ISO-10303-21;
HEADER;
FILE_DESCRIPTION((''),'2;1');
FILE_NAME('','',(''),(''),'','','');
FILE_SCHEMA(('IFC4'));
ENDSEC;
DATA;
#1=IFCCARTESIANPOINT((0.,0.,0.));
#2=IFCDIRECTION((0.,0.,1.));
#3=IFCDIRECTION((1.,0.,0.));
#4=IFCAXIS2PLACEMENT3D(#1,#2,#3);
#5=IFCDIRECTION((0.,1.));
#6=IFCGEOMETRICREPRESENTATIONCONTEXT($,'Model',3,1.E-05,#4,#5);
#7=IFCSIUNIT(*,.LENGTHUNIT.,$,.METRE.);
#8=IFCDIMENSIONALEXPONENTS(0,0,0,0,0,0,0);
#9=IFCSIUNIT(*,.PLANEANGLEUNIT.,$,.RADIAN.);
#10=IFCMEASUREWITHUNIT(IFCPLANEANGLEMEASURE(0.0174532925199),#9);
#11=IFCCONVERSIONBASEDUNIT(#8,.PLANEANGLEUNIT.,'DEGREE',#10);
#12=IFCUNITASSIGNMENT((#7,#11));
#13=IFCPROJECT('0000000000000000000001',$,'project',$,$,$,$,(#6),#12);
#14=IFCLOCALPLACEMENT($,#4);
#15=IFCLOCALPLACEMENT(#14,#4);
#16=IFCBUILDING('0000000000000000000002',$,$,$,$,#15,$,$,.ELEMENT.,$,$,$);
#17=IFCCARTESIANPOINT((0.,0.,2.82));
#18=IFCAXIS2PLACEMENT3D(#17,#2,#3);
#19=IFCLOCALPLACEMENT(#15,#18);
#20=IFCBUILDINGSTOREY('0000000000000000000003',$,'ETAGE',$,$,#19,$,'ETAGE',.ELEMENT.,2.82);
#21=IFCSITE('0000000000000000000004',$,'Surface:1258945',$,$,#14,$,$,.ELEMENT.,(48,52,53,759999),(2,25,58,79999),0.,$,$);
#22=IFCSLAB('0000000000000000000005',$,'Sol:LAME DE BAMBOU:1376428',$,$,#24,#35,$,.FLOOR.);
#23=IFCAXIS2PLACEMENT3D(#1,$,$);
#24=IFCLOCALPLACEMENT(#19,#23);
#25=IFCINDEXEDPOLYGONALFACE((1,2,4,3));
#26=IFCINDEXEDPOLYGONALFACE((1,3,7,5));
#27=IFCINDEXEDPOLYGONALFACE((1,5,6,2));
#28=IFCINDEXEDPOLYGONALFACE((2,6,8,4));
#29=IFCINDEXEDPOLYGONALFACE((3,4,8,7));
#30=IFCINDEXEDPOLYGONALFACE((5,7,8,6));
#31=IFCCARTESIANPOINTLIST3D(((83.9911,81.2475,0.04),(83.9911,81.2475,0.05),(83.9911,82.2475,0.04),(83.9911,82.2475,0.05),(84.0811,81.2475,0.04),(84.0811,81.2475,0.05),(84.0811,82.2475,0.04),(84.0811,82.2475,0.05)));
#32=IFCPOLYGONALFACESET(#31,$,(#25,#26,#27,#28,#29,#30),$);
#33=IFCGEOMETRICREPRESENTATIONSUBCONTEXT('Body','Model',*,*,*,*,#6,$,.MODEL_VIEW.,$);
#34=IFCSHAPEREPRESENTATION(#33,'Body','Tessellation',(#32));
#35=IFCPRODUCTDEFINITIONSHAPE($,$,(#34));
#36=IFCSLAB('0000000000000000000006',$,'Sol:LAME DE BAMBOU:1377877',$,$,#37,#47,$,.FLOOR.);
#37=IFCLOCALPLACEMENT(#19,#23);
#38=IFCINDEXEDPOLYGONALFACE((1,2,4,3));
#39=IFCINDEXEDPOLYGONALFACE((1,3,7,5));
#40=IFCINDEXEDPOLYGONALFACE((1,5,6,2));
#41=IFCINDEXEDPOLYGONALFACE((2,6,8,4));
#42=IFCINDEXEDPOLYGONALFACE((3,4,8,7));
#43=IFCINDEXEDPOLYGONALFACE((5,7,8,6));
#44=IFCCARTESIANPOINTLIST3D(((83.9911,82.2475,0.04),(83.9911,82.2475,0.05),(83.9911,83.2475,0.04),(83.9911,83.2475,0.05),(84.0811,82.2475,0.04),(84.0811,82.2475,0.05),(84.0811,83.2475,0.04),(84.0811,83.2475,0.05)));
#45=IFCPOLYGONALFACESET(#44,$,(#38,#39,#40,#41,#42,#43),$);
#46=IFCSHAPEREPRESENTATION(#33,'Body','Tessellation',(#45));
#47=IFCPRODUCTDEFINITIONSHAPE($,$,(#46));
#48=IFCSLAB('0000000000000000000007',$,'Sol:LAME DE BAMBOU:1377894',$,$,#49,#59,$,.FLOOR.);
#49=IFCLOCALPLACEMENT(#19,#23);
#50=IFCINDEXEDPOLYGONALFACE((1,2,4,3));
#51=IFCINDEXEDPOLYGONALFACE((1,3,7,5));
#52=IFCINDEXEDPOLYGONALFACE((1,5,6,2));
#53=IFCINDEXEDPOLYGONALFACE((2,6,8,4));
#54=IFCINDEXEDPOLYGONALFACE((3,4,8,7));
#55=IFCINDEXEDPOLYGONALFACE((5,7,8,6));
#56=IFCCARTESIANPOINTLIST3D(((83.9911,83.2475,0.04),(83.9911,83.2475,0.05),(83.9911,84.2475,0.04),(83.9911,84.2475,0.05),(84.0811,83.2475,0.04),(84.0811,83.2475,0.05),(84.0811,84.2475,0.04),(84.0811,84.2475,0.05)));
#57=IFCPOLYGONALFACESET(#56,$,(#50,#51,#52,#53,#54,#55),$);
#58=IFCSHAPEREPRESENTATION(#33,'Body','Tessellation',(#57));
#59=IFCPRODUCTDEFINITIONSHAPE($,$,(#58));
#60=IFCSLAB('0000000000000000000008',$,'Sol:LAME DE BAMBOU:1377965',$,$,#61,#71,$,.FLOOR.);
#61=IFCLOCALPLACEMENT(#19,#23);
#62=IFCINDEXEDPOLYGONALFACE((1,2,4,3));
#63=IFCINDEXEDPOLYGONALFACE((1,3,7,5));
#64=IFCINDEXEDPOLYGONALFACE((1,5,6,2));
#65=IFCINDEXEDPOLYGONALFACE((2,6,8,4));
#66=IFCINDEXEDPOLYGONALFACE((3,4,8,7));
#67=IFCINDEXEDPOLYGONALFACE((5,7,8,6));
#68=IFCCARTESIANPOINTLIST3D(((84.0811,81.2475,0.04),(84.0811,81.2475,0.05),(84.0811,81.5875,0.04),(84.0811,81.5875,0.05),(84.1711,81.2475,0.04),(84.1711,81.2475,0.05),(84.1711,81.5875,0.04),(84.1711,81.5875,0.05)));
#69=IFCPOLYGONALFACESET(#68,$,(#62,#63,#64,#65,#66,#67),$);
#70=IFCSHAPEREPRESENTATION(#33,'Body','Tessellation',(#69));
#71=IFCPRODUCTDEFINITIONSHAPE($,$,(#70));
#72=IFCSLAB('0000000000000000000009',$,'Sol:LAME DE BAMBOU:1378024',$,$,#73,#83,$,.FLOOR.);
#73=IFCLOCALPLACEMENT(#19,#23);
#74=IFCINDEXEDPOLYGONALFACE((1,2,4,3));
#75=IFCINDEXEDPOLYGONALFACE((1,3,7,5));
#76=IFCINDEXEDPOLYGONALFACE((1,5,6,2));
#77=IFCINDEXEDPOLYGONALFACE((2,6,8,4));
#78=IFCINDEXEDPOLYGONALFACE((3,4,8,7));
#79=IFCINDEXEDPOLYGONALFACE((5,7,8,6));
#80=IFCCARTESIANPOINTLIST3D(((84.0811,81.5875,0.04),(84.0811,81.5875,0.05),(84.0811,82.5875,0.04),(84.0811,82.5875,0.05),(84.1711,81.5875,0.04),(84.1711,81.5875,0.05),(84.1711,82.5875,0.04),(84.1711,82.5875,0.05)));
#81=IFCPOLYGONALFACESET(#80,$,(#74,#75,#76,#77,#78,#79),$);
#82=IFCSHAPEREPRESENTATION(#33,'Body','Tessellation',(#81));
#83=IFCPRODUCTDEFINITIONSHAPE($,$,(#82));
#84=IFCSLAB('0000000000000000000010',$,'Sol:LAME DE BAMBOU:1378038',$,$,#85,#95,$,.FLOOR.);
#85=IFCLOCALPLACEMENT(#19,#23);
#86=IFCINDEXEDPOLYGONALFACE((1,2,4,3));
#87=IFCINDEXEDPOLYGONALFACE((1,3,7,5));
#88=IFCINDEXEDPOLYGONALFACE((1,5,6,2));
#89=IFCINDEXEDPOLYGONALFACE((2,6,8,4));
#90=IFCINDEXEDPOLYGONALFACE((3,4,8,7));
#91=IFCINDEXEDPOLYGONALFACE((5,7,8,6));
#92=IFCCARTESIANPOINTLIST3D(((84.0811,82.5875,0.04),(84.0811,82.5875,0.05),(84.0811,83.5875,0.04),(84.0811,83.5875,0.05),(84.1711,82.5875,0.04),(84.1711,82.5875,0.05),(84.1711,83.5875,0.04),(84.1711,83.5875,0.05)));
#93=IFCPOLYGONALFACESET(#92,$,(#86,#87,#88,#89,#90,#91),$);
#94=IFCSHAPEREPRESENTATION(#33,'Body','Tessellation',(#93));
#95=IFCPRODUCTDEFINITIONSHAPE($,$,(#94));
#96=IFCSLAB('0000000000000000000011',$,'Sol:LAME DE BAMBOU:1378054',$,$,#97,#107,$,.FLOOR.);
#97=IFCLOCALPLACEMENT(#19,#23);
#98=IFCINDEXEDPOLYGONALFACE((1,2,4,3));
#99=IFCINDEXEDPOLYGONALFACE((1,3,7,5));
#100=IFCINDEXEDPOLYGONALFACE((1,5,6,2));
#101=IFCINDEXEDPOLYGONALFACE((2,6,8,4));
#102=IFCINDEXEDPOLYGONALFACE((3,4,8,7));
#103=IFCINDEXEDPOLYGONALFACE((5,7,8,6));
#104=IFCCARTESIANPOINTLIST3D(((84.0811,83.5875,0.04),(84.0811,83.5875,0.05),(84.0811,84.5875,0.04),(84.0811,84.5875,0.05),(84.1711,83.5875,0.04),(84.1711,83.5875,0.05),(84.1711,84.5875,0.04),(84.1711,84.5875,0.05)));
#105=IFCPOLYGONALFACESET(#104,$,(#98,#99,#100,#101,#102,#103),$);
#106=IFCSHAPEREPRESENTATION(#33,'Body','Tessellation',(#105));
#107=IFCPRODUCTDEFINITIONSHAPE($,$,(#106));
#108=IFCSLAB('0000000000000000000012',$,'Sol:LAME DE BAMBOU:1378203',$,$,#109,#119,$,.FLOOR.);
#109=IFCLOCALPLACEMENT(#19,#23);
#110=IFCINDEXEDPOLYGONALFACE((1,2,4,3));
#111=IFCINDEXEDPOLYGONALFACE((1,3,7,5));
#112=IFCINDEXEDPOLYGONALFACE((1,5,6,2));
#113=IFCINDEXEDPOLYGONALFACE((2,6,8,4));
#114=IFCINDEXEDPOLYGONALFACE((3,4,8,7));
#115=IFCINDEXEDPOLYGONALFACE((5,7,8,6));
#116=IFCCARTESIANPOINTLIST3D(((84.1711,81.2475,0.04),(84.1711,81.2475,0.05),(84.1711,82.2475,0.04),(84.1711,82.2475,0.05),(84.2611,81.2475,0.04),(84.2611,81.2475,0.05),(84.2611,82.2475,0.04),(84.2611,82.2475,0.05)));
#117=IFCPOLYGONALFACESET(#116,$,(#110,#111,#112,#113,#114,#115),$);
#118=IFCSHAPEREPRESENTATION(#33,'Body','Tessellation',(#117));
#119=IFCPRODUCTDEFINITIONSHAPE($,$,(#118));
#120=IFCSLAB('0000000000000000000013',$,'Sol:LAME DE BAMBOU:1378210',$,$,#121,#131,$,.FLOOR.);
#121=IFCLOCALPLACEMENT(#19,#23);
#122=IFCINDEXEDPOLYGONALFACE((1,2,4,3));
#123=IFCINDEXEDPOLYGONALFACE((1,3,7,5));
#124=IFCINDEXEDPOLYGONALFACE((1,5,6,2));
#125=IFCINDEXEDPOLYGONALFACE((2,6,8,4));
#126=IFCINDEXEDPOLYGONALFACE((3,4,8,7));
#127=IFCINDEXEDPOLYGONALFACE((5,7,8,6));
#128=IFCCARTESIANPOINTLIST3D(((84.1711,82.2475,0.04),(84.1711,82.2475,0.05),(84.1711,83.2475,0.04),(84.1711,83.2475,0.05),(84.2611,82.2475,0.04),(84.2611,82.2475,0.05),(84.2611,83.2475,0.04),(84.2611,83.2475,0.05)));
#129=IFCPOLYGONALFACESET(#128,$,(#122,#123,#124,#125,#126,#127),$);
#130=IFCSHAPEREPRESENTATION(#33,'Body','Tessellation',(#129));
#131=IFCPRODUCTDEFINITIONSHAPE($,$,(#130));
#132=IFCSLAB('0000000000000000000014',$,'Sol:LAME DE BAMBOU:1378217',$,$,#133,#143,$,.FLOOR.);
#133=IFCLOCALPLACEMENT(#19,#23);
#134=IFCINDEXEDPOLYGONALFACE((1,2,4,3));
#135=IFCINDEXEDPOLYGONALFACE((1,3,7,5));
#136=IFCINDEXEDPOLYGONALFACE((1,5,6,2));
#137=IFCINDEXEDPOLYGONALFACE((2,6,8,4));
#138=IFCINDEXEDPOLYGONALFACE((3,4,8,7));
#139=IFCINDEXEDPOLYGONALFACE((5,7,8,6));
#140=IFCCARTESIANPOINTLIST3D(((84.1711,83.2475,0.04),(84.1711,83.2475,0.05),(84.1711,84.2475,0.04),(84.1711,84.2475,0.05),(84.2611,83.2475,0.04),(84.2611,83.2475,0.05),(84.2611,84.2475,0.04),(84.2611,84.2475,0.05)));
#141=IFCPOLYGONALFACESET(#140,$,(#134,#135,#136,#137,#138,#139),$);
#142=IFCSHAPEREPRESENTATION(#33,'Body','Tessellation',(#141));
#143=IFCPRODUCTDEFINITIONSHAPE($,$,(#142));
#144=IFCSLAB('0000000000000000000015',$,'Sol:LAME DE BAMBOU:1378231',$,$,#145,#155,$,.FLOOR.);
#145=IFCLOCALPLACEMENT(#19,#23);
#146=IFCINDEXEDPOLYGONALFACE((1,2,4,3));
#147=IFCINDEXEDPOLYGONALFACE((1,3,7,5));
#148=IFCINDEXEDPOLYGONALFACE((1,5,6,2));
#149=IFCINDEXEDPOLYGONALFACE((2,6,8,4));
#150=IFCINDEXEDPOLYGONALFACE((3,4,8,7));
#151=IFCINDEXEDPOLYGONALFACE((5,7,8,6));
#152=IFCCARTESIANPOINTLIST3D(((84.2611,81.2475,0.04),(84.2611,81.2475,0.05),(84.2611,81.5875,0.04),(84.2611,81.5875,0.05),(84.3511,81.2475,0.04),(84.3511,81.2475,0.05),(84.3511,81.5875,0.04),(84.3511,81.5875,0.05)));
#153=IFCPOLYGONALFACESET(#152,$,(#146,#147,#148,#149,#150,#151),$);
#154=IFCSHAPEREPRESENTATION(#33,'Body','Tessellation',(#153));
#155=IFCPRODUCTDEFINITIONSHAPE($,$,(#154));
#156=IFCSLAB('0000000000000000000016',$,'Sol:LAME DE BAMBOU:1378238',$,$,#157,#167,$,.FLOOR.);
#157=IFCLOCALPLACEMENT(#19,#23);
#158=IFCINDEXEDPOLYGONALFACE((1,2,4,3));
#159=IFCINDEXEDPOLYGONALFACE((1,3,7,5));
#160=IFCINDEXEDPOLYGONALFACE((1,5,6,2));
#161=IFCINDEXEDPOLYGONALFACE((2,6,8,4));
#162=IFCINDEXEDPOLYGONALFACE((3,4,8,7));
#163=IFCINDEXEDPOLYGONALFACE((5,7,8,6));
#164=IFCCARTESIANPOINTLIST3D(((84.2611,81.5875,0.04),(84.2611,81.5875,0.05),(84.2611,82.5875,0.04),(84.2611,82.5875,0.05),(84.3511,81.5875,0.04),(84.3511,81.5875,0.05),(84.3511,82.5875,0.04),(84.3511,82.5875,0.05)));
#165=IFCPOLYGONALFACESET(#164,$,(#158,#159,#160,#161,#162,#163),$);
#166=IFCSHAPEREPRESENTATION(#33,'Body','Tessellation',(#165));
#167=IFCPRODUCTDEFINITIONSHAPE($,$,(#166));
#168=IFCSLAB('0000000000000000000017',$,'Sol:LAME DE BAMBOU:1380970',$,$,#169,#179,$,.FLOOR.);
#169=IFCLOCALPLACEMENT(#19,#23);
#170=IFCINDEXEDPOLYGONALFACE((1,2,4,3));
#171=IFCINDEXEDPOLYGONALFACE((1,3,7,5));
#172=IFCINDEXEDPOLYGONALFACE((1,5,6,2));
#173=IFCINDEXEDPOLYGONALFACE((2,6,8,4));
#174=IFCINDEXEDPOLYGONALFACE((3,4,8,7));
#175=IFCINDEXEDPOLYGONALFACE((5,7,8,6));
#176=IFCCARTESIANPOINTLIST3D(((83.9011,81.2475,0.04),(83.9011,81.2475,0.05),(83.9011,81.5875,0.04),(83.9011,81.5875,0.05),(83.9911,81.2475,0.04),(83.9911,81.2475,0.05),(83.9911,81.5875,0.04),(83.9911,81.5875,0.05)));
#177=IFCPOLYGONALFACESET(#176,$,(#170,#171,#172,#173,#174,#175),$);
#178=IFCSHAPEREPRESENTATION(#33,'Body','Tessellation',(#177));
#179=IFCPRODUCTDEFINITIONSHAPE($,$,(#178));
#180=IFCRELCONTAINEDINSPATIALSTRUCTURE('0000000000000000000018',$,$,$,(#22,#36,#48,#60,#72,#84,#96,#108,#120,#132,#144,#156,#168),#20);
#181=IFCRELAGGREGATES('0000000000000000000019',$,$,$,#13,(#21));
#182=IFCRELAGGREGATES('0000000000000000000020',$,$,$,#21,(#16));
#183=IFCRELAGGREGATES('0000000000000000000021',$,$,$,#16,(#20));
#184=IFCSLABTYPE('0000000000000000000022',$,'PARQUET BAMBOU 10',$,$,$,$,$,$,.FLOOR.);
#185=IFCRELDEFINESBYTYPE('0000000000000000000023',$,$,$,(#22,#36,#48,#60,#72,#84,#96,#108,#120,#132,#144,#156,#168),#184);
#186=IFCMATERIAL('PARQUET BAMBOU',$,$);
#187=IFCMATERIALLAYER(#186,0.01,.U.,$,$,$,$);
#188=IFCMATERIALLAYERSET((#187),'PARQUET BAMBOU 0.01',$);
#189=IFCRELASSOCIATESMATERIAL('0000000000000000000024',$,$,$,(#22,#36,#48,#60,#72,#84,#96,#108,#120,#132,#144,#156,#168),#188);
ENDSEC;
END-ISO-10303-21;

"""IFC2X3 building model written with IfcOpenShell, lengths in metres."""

from ifc_helpers import new_model, entity, si_unit, converted_unit, direction, frame, origin_with_axes, place, context, subcontext, project, spatial, polyline, outline, extrude, material, layer, layer_set, layer_usage, type_object, element, save


model = new_model("IFC2X3")

# Units and contexts
model_context = context("Model", 3, precision=1e-05, world=origin_with_axes(), true_north=direction((0.0, 1.0)))
body_context = subcontext(model_context, "Body", "Model", "MODEL_VIEW")
ifc_project = project(units=[si_unit("LENGTHUNIT", "METRE"), converted_unit("PLANEANGLEUNIT", "DEGREE", entity("IfcPlaneAngleMeasure", 0.0174532925199), si_unit("PLANEANGLEUNIT", "RADIAN"), dimensions=[0, 0, 0, 0, 0, 0, 0])], contexts=[model_context])

# Site, building, storey
site_placement = place(None, origin_with_axes())
site = spatial("IfcSite", under=ifc_project, at=site_placement, Name="Surface:1258945", CompositionType="ELEMENT", RefLatitude=(48, 52, 53, 759999), RefLongitude=(2, 25, 58, 79999), RefElevation=0.0)
building_placement = place(site_placement, origin_with_axes())
building = spatial("IfcBuilding", under=site, at=building_placement, CompositionType="ELEMENT")
storey_placement = place(building_placement, frame((0.0, 0.0, 2.82), z_axis=(0.0, 0.0, 1.0), x_axis=(1.0, 0.0, 0.0)))
storey = spatial("IfcBuildingStorey", under=building, at=storey_placement, Name="ETAGE", LongName="ETAGE", CompositionType="ELEMENT", Elevation=2.82)

# Slabs
ifc_material_1 = material(Name="PARQUET BAMBOU")
ifc_layer_1 = layer(ifc_material_1, 0.01, ventilated="UNKNOWN")
ifc_layer_set_1 = layer_set([ifc_layer_1], Name="PARQUET BAMBOU 0.01")
ifc_layer_usage_1 = layer_usage(ifc_layer_set_1, "AXIS3", "NEGATIVE", 0.01)
slab_type = type_object("IfcSlabType", Name="PARQUET BAMBOU 10", PredefinedType="FLOOR")
slab_1_placement = place(storey_placement, frame((83.9911, 82.2475, 0.05), z_axis=(0.0, 0.0, 1.0), x_axis=(1.0, 0.0, 0.0)))
element("IfcSlab", 1, at=slab_1_placement, inside=storey, type_object=slab_type, material=ifc_layer_usage_1, Name="Sol:LAME DE BAMBOU:1376428", PredefinedType="FLOOR", context=body_context, shape_type="SweptSolid", body=[
    extrude(outline(polyline([(0.0, 0.0), (0.0, -1.0), (0.09, -1.0), (0.09, 0.0), (0.0, 0.0)])), frame((0.0, 0.0, -0.01), z_axis=(0.0, 0.0, 1.0), x_axis=(1.0, 0.0, 0.0)), (0.0, 0.0, 1.0), 0.01),
])
ifc_layer_usage_2 = layer_usage(ifc_layer_set_1, "AXIS3", "NEGATIVE", 0.01)
slab_2_placement = place(storey_placement, frame((83.9911, 83.2475, 0.05), z_axis=(0.0, 0.0, 1.0), x_axis=(1.0, 0.0, 0.0)))
element("IfcSlab", 2, at=slab_2_placement, inside=storey, type_object=slab_type, material=ifc_layer_usage_2, Name="Sol:LAME DE BAMBOU:1377877", PredefinedType="FLOOR", context=body_context, shape_type="SweptSolid", body=[
    extrude(outline(polyline([(0.0, 0.0), (0.0, -1.0), (0.09, -1.0), (0.09, 0.0), (0.0, 0.0)])), frame((0.0, 0.0, -0.01), z_axis=(0.0, 0.0, 1.0), x_axis=(1.0, 0.0, 0.0)), (0.0, 0.0, 1.0), 0.01),
])
ifc_layer_usage_3 = layer_usage(ifc_layer_set_1, "AXIS3", "NEGATIVE", 0.01)
slab_3_placement = place(storey_placement, frame((83.9911, 84.2475, 0.05), z_axis=(0.0, 0.0, 1.0), x_axis=(1.0, 0.0, 0.0)))
element("IfcSlab", 3, at=slab_3_placement, inside=storey, type_object=slab_type, material=ifc_layer_usage_3, Name="Sol:LAME DE BAMBOU:1377894", PredefinedType="FLOOR", context=body_context, shape_type="SweptSolid", body=[
    extrude(outline(polyline([(0.0, 0.0), (0.0, -1.0), (0.09, -1.0), (0.09, 0.0), (0.0, 0.0)])), frame((0.0, 0.0, -0.01), z_axis=(0.0, 0.0, 1.0), x_axis=(1.0, 0.0, 0.0)), (0.0, 0.0, 1.0), 0.01),
])
ifc_layer_usage_4 = layer_usage(ifc_layer_set_1, "AXIS3", "NEGATIVE", 0.01)
slab_4_placement = place(storey_placement, frame((84.0811, 81.5875, 0.05), z_axis=(0.0, 0.0, 1.0), x_axis=(1.0, 0.0, 0.0)))
element("IfcSlab", 4, at=slab_4_placement, inside=storey, type_object=slab_type, material=ifc_layer_usage_4, Name="Sol:LAME DE BAMBOU:1377965", PredefinedType="FLOOR", context=body_context, shape_type="SweptSolid", body=[
    extrude(outline(polyline([(0.0, 0.0), (0.0, -0.34), (0.09, -0.34), (0.09, 0.0), (0.0, 0.0)])), frame((0.0, 0.0, -0.01), z_axis=(0.0, 0.0, 1.0), x_axis=(1.0, 0.0, 0.0)), (0.0, 0.0, 1.0), 0.01),
])
ifc_layer_usage_5 = layer_usage(ifc_layer_set_1, "AXIS3", "NEGATIVE", 0.01)
slab_5_placement = place(storey_placement, frame((84.0811, 82.5875, 0.05), z_axis=(0.0, 0.0, 1.0), x_axis=(1.0, 0.0, 0.0)))
element("IfcSlab", 5, at=slab_5_placement, inside=storey, type_object=slab_type, material=ifc_layer_usage_5, Name="Sol:LAME DE BAMBOU:1378024", PredefinedType="FLOOR", context=body_context, shape_type="SweptSolid", body=[
    extrude(outline(polyline([(0.0, 0.0), (0.0, -1.0), (0.09, -1.0), (0.09, 0.0), (0.0, 0.0)])), frame((0.0, 0.0, -0.01), z_axis=(0.0, 0.0, 1.0), x_axis=(1.0, 0.0, 0.0)), (0.0, 0.0, 1.0), 0.01),
])
ifc_layer_usage_6 = layer_usage(ifc_layer_set_1, "AXIS3", "NEGATIVE", 0.01)
slab_6_placement = place(storey_placement, frame((84.0811, 83.5875, 0.05), z_axis=(0.0, 0.0, 1.0), x_axis=(1.0, 0.0, 0.0)))
element("IfcSlab", 6, at=slab_6_placement, inside=storey, type_object=slab_type, material=ifc_layer_usage_6, Name="Sol:LAME DE BAMBOU:1378038", PredefinedType="FLOOR", context=body_context, shape_type="SweptSolid", body=[
    extrude(outline(polyline([(0.0, 0.0), (0.0, -1.0), (0.09, -1.0), (0.09, 0.0), (0.0, 0.0)])), frame((0.0, 0.0, -0.01), z_axis=(0.0, 0.0, 1.0), x_axis=(1.0, 0.0, 0.0)), (0.0, 0.0, 1.0), 0.01),
])
ifc_layer_usage_7 = layer_usage(ifc_layer_set_1, "AXIS3", "NEGATIVE", 0.01)
slab_7_placement = place(storey_placement, frame((84.0811, 84.5875, 0.05), z_axis=(0.0, 0.0, 1.0), x_axis=(1.0, 0.0, 0.0)))
element("IfcSlab", 7, at=slab_7_placement, inside=storey, type_object=slab_type, material=ifc_layer_usage_7, Name="Sol:LAME DE BAMBOU:1378054", PredefinedType="FLOOR", context=body_context, shape_type="SweptSolid", body=[
    extrude(outline(polyline([(0.0, 0.0), (0.0, -1.0), (0.09, -1.0), (0.09, 0.0), (0.0, 0.0)])), frame((0.0, 0.0, -0.01), z_axis=(0.0, 0.0, 1.0), x_axis=(1.0, 0.0, 0.0)), (0.0, 0.0, 1.0), 0.01),
])
ifc_layer_usage_8 = layer_usage(ifc_layer_set_1, "AXIS3", "NEGATIVE", 0.01)
slab_8_placement = place(storey_placement, frame((84.1711, 82.2475, 0.05), z_axis=(0.0, 0.0, 1.0), x_axis=(1.0, 0.0, 0.0)))
element("IfcSlab", 8, at=slab_8_placement, inside=storey, type_object=slab_type, material=ifc_layer_usage_8, Name="Sol:LAME DE BAMBOU:1378203", PredefinedType="FLOOR", context=body_context, shape_type="SweptSolid", body=[
    extrude(outline(polyline([(0.0, 0.0), (0.0, -1.0), (0.09, -1.0), (0.09, 0.0), (0.0, 0.0)])), frame((0.0, 0.0, -0.01), z_axis=(0.0, 0.0, 1.0), x_axis=(1.0, 0.0, 0.0)), (0.0, 0.0, 1.0), 0.01),
])
ifc_layer_usage_9 = layer_usage(ifc_layer_set_1, "AXIS3", "NEGATIVE", 0.01)
slab_9_placement = place(storey_placement, frame((84.1711, 83.2475, 0.05), z_axis=(0.0, 0.0, 1.0), x_axis=(1.0, 0.0, 0.0)))
element("IfcSlab", 9, at=slab_9_placement, inside=storey, type_object=slab_type, material=ifc_layer_usage_9, Name="Sol:LAME DE BAMBOU:1378210", PredefinedType="FLOOR", context=body_context, shape_type="SweptSolid", body=[
    extrude(outline(polyline([(0.0, 0.0), (0.0, -1.0), (0.09, -1.0), (0.09, 0.0), (0.0, 0.0)])), frame((0.0, 0.0, -0.01), z_axis=(0.0, 0.0, 1.0), x_axis=(1.0, 0.0, 0.0)), (0.0, 0.0, 1.0), 0.01),
])
ifc_layer_usage_10 = layer_usage(ifc_layer_set_1, "AXIS3", "NEGATIVE", 0.01)
slab_10_placement = place(storey_placement, frame((84.1711, 84.2475, 0.05), z_axis=(0.0, 0.0, 1.0), x_axis=(1.0, 0.0, 0.0)))
element("IfcSlab", 10, at=slab_10_placement, inside=storey, type_object=slab_type, material=ifc_layer_usage_10, Name="Sol:LAME DE BAMBOU:1378217", PredefinedType="FLOOR", context=body_context, shape_type="SweptSolid", body=[
    extrude(outline(polyline([(0.0, 0.0), (0.0, -1.0), (0.09, -1.0), (0.09, 0.0), (0.0, 0.0)])), frame((0.0, 0.0, -0.01), z_axis=(0.0, 0.0, 1.0), x_axis=(1.0, 0.0, 0.0)), (0.0, 0.0, 1.0), 0.01),
])
ifc_layer_usage_11 = layer_usage(ifc_layer_set_1, "AXIS3", "NEGATIVE", 0.01)
slab_11_placement = place(storey_placement, frame((84.2611, 81.5875, 0.05), z_axis=(0.0, 0.0, 1.0), x_axis=(1.0, 0.0, 0.0)))
element("IfcSlab", 11, at=slab_11_placement, inside=storey, type_object=slab_type, material=ifc_layer_usage_11, Name="Sol:LAME DE BAMBOU:1378231", PredefinedType="FLOOR", context=body_context, shape_type="SweptSolid", body=[
    extrude(outline(polyline([(0.0, 0.0), (0.0, -0.34), (0.09, -0.34), (0.09, 0.0), (0.0, 0.0)])), frame((0.0, 0.0, -0.01), z_axis=(0.0, 0.0, 1.0), x_axis=(1.0, 0.0, 0.0)), (0.0, 0.0, 1.0), 0.01),
])
ifc_layer_usage_12 = layer_usage(ifc_layer_set_1, "AXIS3", "NEGATIVE", 0.01)
slab_12_placement = place(storey_placement, frame((84.2611, 82.5875, 0.05), z_axis=(0.0, 0.0, 1.0), x_axis=(1.0, 0.0, 0.0)))
element("IfcSlab", 12, at=slab_12_placement, inside=storey, type_object=slab_type, material=ifc_layer_usage_12, Name="Sol:LAME DE BAMBOU:1378238", PredefinedType="FLOOR", context=body_context, shape_type="SweptSolid", body=[
    extrude(outline(polyline([(0.0, 0.0), (0.0, -1.0), (0.09, -1.0), (0.09, 0.0), (0.0, 0.0)])), frame((0.0, 0.0, -0.01), z_axis=(0.0, 0.0, 1.0), x_axis=(1.0, 0.0, 0.0)), (0.0, 0.0, 1.0), 0.01),
])
ifc_layer_usage_13 = layer_usage(ifc_layer_set_1, "AXIS3", "NEGATIVE", 0.01)
slab_13_placement = place(storey_placement, frame((83.9011, 81.5875, 0.05), z_axis=(0.0, 0.0, 1.0), x_axis=(1.0, 0.0, 0.0)))
element("IfcSlab", 13, at=slab_13_placement, inside=storey, type_object=slab_type, material=ifc_layer_usage_13, Name="Sol:LAME DE BAMBOU:1380970", PredefinedType="FLOOR", context=body_context, shape_type="SweptSolid", body=[
    extrude(outline(polyline([(0.0, 0.0), (0.0, -0.34), (0.09, -0.34), (0.09, 0.0), (0.0, 0.0)])), frame((0.0, 0.0, -0.01), z_axis=(0.0, 0.0, 1.0), x_axis=(1.0, 0.0, 0.0)), (0.0, 0.0, 1.0), 0.01),
])

save(model, "model.ifc")
